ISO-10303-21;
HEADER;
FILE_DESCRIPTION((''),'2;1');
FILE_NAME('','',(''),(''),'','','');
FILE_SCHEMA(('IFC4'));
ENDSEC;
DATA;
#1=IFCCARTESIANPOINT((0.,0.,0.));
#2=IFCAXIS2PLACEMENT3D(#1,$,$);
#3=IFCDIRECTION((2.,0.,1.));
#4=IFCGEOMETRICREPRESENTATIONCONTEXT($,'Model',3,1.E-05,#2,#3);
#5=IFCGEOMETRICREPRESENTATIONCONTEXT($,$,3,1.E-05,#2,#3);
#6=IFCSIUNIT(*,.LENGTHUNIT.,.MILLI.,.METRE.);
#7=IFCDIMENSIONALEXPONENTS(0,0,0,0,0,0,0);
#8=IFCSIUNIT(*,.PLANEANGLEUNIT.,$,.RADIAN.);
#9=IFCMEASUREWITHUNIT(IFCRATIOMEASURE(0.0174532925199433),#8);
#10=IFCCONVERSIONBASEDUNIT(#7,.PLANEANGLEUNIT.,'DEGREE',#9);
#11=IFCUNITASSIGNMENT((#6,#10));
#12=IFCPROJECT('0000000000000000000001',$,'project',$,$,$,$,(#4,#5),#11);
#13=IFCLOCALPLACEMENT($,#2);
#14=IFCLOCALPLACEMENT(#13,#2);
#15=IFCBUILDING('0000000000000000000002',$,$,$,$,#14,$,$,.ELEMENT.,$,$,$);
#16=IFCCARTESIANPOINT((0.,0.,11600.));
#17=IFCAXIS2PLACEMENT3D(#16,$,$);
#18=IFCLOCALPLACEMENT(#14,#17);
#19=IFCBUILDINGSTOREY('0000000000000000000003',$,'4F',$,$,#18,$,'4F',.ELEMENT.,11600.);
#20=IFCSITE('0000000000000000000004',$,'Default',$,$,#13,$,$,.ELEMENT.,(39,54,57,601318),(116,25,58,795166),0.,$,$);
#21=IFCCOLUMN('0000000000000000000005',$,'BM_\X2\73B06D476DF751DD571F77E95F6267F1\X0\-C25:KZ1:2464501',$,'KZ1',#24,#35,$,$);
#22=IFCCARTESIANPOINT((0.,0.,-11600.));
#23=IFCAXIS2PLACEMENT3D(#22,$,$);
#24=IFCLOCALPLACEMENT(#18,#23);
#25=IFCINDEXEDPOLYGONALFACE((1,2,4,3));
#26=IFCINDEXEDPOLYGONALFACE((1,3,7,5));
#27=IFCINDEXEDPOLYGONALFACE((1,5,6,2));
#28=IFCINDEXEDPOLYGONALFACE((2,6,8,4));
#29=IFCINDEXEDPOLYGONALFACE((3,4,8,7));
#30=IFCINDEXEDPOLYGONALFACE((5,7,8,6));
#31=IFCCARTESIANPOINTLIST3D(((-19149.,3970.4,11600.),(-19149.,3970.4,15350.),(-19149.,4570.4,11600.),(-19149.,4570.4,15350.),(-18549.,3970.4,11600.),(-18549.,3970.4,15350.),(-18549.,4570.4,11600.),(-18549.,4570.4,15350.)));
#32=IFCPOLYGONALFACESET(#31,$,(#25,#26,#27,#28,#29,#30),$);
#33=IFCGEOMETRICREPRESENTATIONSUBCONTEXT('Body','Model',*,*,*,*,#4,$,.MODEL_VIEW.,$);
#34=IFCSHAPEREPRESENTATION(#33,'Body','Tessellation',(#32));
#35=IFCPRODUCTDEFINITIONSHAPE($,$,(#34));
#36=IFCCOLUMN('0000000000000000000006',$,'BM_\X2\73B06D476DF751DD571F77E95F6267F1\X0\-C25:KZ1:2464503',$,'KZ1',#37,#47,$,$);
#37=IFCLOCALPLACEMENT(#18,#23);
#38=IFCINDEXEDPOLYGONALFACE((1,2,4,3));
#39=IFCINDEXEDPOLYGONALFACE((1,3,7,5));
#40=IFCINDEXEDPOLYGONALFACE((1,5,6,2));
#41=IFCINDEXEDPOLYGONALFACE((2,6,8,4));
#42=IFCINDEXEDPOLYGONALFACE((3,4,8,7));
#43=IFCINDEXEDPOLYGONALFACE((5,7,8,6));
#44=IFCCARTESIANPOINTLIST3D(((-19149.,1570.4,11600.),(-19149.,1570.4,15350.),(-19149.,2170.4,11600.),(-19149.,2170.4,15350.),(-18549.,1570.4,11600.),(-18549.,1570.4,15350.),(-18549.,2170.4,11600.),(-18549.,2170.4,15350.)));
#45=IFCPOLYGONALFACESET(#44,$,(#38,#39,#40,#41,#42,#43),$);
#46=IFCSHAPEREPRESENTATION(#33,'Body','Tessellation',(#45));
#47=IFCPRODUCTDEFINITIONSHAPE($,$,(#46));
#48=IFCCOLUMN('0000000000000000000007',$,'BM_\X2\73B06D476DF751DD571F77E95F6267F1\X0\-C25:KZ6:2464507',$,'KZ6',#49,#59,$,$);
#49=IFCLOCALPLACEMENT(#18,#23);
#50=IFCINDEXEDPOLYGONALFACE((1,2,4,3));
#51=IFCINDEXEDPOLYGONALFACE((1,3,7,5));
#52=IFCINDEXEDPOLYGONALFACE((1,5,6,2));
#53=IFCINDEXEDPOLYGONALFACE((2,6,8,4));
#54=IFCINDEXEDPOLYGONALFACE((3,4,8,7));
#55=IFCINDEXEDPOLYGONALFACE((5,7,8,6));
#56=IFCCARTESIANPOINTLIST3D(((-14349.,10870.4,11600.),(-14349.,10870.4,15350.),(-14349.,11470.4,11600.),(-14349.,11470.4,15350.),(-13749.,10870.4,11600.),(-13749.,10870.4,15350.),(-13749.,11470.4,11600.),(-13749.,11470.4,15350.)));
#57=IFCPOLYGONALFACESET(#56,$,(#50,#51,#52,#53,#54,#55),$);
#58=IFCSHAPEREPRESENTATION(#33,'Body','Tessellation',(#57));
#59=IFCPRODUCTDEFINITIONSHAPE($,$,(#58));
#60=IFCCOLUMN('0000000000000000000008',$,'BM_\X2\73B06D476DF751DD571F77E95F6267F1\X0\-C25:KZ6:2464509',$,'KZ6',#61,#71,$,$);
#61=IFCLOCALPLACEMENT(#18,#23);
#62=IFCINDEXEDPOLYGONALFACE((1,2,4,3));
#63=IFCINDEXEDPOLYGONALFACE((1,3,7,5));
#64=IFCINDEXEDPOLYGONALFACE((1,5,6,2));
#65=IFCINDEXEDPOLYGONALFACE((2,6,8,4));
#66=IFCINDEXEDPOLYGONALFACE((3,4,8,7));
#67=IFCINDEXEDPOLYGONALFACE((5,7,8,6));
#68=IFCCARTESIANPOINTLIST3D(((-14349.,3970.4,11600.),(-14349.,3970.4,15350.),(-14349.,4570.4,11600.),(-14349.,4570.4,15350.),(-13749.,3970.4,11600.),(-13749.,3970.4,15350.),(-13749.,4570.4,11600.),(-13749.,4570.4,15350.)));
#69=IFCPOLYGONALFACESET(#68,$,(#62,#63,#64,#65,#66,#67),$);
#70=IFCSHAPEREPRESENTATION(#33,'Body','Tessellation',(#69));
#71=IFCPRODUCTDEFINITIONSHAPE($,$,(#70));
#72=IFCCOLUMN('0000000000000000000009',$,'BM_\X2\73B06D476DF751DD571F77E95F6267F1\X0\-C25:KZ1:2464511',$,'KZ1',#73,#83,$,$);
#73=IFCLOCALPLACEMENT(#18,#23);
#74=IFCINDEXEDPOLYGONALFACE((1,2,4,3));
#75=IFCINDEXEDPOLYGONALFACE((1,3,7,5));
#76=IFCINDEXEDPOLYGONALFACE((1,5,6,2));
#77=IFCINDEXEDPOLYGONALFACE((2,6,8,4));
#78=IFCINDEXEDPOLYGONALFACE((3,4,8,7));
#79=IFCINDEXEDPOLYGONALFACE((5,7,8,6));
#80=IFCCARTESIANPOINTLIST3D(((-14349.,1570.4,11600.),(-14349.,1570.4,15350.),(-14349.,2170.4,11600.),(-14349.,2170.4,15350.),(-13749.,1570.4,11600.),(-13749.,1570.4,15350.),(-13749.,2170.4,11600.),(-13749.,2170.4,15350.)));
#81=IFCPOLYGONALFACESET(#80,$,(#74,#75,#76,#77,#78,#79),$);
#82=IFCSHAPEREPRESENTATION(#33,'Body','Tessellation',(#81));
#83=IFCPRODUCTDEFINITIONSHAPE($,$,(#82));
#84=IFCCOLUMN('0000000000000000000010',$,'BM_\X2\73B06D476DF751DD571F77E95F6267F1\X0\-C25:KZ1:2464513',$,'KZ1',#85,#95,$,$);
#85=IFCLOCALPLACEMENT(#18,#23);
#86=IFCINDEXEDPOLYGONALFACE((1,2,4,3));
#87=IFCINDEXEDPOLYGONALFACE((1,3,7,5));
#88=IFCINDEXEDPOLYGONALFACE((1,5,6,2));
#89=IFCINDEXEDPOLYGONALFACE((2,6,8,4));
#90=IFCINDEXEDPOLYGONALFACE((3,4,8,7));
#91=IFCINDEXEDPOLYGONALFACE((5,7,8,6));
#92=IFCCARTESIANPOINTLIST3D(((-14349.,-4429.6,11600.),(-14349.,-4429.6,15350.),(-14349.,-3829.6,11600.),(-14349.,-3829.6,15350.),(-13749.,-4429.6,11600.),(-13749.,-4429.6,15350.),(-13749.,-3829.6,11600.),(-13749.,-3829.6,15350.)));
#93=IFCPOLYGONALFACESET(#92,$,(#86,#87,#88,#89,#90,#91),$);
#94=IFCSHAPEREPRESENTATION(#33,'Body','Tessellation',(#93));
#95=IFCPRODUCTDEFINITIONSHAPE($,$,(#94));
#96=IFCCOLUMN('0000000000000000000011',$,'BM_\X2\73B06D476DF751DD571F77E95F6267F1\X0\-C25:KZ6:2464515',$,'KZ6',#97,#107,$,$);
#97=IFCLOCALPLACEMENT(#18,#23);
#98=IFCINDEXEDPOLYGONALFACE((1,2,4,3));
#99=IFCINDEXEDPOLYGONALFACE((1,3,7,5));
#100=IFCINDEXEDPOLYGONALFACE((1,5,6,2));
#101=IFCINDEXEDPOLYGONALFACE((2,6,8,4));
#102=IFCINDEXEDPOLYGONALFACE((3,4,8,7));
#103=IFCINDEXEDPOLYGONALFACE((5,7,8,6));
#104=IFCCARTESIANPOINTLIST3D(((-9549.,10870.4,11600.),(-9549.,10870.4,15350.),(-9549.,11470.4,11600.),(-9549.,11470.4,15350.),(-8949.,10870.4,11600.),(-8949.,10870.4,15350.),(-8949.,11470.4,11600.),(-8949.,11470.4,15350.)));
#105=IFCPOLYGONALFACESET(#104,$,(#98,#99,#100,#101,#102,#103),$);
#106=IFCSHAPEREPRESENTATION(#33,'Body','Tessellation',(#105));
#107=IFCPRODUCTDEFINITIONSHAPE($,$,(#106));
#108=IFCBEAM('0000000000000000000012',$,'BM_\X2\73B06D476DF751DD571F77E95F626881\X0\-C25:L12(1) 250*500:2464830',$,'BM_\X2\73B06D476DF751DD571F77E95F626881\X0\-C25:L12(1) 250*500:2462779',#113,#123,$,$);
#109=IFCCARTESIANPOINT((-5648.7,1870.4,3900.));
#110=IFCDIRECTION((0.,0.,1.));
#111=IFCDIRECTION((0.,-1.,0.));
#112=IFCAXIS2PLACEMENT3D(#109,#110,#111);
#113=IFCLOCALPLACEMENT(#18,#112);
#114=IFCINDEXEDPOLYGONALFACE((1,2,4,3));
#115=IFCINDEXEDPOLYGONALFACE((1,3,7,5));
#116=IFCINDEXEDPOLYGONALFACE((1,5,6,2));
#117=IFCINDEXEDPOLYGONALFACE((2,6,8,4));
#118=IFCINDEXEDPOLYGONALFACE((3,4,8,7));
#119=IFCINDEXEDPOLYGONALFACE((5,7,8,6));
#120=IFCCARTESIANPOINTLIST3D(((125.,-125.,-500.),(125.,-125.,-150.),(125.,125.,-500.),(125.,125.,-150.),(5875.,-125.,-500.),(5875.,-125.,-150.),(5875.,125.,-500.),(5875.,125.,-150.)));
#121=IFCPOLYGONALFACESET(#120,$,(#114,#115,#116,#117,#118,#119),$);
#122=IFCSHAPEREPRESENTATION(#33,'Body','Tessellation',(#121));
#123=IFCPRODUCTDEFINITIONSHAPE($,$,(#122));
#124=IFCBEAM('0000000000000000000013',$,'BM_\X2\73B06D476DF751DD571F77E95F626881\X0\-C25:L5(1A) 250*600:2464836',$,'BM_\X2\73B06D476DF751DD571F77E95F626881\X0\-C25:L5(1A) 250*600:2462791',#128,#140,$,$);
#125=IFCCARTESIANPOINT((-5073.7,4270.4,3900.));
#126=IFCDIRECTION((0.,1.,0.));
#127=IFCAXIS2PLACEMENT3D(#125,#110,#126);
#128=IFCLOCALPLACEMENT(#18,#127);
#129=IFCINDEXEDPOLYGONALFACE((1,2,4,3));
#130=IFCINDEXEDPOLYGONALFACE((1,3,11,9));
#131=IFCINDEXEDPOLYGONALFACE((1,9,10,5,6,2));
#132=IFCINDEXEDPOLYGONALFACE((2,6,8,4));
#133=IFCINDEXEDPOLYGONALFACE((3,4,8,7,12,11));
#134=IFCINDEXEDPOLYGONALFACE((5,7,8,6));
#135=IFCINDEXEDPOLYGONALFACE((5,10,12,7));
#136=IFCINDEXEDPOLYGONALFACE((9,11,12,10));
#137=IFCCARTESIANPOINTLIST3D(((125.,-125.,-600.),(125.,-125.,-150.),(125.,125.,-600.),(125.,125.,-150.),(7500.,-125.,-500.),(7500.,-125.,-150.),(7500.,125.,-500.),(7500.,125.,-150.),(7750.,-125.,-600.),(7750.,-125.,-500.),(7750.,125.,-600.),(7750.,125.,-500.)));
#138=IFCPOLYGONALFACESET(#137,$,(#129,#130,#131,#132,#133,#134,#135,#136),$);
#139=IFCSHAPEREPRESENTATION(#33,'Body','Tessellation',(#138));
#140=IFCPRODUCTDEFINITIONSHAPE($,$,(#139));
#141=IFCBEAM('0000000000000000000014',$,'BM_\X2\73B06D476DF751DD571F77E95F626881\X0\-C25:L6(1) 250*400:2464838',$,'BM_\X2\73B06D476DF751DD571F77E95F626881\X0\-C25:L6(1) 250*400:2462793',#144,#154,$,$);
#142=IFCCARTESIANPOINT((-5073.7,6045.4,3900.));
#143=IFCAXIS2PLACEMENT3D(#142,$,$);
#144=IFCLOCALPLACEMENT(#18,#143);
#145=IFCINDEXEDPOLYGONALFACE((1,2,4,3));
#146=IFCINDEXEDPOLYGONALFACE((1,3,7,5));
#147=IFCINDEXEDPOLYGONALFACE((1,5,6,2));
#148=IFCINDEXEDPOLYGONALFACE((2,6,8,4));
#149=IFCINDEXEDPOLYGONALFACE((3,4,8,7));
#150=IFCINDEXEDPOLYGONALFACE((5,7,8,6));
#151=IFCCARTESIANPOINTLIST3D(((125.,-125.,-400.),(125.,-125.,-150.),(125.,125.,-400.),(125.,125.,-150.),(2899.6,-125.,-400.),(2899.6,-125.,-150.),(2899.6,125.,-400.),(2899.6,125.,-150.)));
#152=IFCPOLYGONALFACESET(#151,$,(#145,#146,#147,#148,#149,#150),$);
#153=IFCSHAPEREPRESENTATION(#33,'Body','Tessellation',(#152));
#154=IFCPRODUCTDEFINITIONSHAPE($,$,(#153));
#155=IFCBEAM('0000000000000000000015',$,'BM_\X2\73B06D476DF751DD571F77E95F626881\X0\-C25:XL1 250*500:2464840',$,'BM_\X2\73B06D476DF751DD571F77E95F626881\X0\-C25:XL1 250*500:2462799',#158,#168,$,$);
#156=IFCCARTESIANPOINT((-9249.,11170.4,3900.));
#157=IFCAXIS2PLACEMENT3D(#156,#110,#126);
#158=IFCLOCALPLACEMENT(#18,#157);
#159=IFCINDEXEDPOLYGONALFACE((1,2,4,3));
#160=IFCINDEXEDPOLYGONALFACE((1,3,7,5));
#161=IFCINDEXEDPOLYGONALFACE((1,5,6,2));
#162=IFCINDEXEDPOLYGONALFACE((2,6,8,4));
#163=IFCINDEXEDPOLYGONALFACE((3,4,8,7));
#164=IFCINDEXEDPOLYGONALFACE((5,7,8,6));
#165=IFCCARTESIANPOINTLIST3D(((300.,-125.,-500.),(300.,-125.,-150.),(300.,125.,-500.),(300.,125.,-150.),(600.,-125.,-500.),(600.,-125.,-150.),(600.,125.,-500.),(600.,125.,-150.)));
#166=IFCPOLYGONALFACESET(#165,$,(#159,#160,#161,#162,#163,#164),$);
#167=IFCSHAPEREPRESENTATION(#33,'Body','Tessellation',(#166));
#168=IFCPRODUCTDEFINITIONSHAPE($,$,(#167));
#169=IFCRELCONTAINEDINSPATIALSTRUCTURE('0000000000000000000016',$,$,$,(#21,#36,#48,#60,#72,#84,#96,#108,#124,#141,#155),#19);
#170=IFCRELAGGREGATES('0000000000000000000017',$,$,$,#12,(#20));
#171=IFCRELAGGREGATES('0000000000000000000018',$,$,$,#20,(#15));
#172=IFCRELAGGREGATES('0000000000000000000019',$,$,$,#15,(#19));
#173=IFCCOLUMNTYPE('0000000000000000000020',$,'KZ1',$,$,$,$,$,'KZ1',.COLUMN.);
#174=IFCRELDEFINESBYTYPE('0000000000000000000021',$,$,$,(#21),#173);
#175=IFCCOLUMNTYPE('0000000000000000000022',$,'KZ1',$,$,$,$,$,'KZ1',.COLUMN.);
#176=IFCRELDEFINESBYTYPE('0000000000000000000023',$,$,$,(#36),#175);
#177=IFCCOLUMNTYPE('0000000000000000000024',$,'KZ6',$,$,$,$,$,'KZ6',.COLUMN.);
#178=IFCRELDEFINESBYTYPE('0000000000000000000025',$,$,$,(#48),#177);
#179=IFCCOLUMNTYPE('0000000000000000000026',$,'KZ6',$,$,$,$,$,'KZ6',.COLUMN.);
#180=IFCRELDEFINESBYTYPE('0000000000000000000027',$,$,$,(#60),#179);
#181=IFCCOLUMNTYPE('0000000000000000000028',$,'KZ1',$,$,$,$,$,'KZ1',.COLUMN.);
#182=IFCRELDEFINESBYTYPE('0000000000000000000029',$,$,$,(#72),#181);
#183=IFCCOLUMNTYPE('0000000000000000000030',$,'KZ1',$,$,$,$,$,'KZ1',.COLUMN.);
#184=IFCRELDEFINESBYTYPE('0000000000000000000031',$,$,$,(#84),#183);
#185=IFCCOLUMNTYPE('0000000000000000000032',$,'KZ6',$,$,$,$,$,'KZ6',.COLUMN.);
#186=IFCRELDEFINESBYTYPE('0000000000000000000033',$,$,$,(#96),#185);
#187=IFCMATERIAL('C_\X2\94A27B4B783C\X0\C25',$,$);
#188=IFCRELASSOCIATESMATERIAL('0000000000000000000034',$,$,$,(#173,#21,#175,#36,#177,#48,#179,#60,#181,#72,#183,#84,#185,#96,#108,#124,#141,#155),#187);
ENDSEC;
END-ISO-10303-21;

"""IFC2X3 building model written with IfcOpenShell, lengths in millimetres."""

from ifc_helpers import new_model, entity, si_unit, converted_unit, direction, frame, frame_2d, origin, place, context, subcontext, project, spatial, polyline, rectangle, extrude, clip, bounded_halfspace, source, transform, mapped, material, type_object, type_shapes, element, save


model = new_model("IFC2X3")

# Units and contexts
model_context = context("Model", 3, precision=1e-05, world=origin(), true_north=direction((2.0, 0.0, 1.0)))
context_of_model = context(None, 3, precision=1e-05, world=origin(), true_north=direction((2.0, 0.0, 1.0)))
body_context = subcontext(model_context, "Body", "Model", "MODEL_VIEW")
ifc_project = project(units=[si_unit("LENGTHUNIT", "METRE", prefix="MILLI"), converted_unit("PLANEANGLEUNIT", "DEGREE", entity("IfcRatioMeasure", 0.0174532925199433), si_unit("PLANEANGLEUNIT", "RADIAN"), dimensions=[0, 0, 0, 0, 0, 0, 0])], contexts=[model_context, context_of_model])

# Site, building, storey
site_placement = place(None, origin())
site = spatial("IfcSite", under=ifc_project, at=site_placement, Name="Default", CompositionType="ELEMENT", RefLatitude=(39, 54, 57, 601318), RefLongitude=(116, 25, 58, 795166), RefElevation=0.0)
building_placement = place(site_placement, origin())
building = spatial("IfcBuilding", under=site, at=building_placement, CompositionType="ELEMENT")
storey_placement = place(building_placement, frame((0.0, 0.0, 11600.0)))
storey = spatial("IfcBuildingStorey", under=building, at=storey_placement, Name="4F", LongName="4F", CompositionType="ELEMENT", Elevation=11600.0)

# Columns
ifc_material = material(Name="C_钢筋砼C25")
column_type_1 = type_object("IfcColumnType", Name="KZ1", ElementType="KZ1", PredefinedType="COLUMN", material=ifc_material)
shared_shape_1 = source(origin(), body_context, "Body", "SweptSolid", [
    extrude(rectangle(XDim=600.0, YDim=600.0, at=frame_2d((0.0, 0.0), x_axis=(1.0, 0.0))), frame((-18849.0, 4270.4, 11600.0), z_axis=(0.0, 0.0, 1.0), x_axis=(-1.0, 0.0, 0.0)), (0.0, 0.0, 1.0), 3750.0),
])
type_shapes(column_type_1, [shared_shape_1])
column_1_placement = place(storey_placement, frame((0.0, 0.0, -11600.0)))
element("IfcColumn", 1, at=column_1_placement, inside=storey, type_object=column_type_1, material=ifc_material, Name="BM_现浇混凝土矩形柱-C25:KZ1:2464501", ObjectType="KZ1", context=body_context, shape_type="MappedRepresentation", body=[
    mapped(shared_shape_1, transform((0.0, 0.0, 0.0), scale=1.0)),
])
column_type_2 = type_object("IfcColumnType", Name="KZ1", ElementType="KZ1", PredefinedType="COLUMN", material=ifc_material)
shared_shape_2 = source(origin(), body_context, "Body", "SweptSolid", [
    extrude(rectangle(XDim=600.0, YDim=600.0, at=frame_2d((0.0, 0.0), x_axis=(1.0, 0.0))), frame((-18849.0, 1870.4, 11600.0), z_axis=(0.0, 0.0, 1.0), x_axis=(-1.0, 0.0, 0.0)), (0.0, 0.0, 1.0), 3750.0),
])
type_shapes(column_type_2, [shared_shape_2])
column_2_placement = place(storey_placement, frame((0.0, 0.0, -11600.0)))
element("IfcColumn", 2, at=column_2_placement, inside=storey, type_object=column_type_2, material=ifc_material, Name="BM_现浇混凝土矩形柱-C25:KZ1:2464503", ObjectType="KZ1", context=body_context, shape_type="MappedRepresentation", body=[
    mapped(shared_shape_2, transform((0.0, 0.0, 0.0), scale=1.0)),
])
column_type_3 = type_object("IfcColumnType", Name="KZ6", ElementType="KZ6", PredefinedType="COLUMN", material=ifc_material)
shared_shape_3 = source(origin(), body_context, "Body", "SweptSolid", [
    extrude(rectangle(XDim=600.0, YDim=600.0, at=frame_2d((0.0, 0.0), x_axis=(1.0, 0.0))), frame((-14049.0, 11170.4, 11600.0), z_axis=(0.0, 0.0, 1.0), x_axis=(-1.0, 0.0, 0.0)), (0.0, 0.0, 1.0), 3750.0),
])
type_shapes(column_type_3, [shared_shape_3])
column_3_placement = place(storey_placement, frame((0.0, 0.0, -11600.0)))
element("IfcColumn", 3, at=column_3_placement, inside=storey, type_object=column_type_3, material=ifc_material, Name="BM_现浇混凝土矩形柱-C25:KZ6:2464507", ObjectType="KZ6", context=body_context, shape_type="MappedRepresentation", body=[
    mapped(shared_shape_3, transform((0.0, 0.0, 0.0), scale=1.0)),
])
column_type_4 = type_object("IfcColumnType", Name="KZ6", ElementType="KZ6", PredefinedType="COLUMN", material=ifc_material)
shared_shape_4 = source(origin(), body_context, "Body", "SweptSolid", [
    extrude(rectangle(XDim=600.0, YDim=600.0, at=frame_2d((0.0, 0.0), x_axis=(1.0, 0.0))), frame((-14049.0, 4270.4, 11600.0), z_axis=(0.0, 0.0, 1.0), x_axis=(-1.0, 0.0, 0.0)), (0.0, 0.0, 1.0), 3750.0),
])
type_shapes(column_type_4, [shared_shape_4])
column_4_placement = place(storey_placement, frame((0.0, 0.0, -11600.0)))
element("IfcColumn", 4, at=column_4_placement, inside=storey, type_object=column_type_4, material=ifc_material, Name="BM_现浇混凝土矩形柱-C25:KZ6:2464509", ObjectType="KZ6", context=body_context, shape_type="MappedRepresentation", body=[
    mapped(shared_shape_4, transform((0.0, 0.0, 0.0), scale=1.0)),
])
column_type_5 = type_object("IfcColumnType", Name="KZ1", ElementType="KZ1", PredefinedType="COLUMN", material=ifc_material)
shared_shape_5 = source(origin(), body_context, "Body", "SweptSolid", [
    extrude(rectangle(XDim=600.0, YDim=600.0, at=frame_2d((0.0, 0.0), x_axis=(1.0, 0.0))), frame((-14049.0, 1870.4, 11600.0), z_axis=(0.0, 0.0, 1.0), x_axis=(-1.0, 0.0, 0.0)), (0.0, 0.0, 1.0), 3750.0),
])
type_shapes(column_type_5, [shared_shape_5])
column_5_placement = place(storey_placement, frame((0.0, 0.0, -11600.0)))
element("IfcColumn", 5, at=column_5_placement, inside=storey, type_object=column_type_5, material=ifc_material, Name="BM_现浇混凝土矩形柱-C25:KZ1:2464511", ObjectType="KZ1", context=body_context, shape_type="MappedRepresentation", body=[
    mapped(shared_shape_5, transform((0.0, 0.0, 0.0), scale=1.0)),
])
column_type_6 = type_object("IfcColumnType", Name="KZ1", ElementType="KZ1", PredefinedType="COLUMN", material=ifc_material)
shared_shape_6 = source(origin(), body_context, "Body", "SweptSolid", [
    extrude(rectangle(XDim=600.0, YDim=600.0, at=frame_2d((0.0, 0.0), x_axis=(1.0, 0.0))), frame((-14049.0, -4129.6, 11600.0), z_axis=(0.0, 0.0, 1.0), x_axis=(-1.0, 0.0, 0.0)), (0.0, 0.0, 1.0), 3750.0),
])
type_shapes(column_type_6, [shared_shape_6])
column_6_placement = place(storey_placement, frame((0.0, 0.0, -11600.0)))
element("IfcColumn", 6, at=column_6_placement, inside=storey, type_object=column_type_6, material=ifc_material, Name="BM_现浇混凝土矩形柱-C25:KZ1:2464513", ObjectType="KZ1", context=body_context, shape_type="MappedRepresentation", body=[
    mapped(shared_shape_6, transform((0.0, 0.0, 0.0), scale=1.0)),
])
column_type_7 = type_object("IfcColumnType", Name="KZ6", ElementType="KZ6", PredefinedType="COLUMN", material=ifc_material)
shared_shape_7 = source(origin(), body_context, "Body", "SweptSolid", [
    extrude(rectangle(XDim=600.0, YDim=600.0, at=frame_2d((0.0, 0.0), x_axis=(1.0, 0.0))), frame((-9249.0, 11170.4, 11600.0), z_axis=(0.0, 0.0, 1.0), x_axis=(-1.0, 0.0, 0.0)), (0.0, 0.0, 1.0), 3750.0),
])
type_shapes(column_type_7, [shared_shape_7])
column_7_placement = place(storey_placement, frame((0.0, 0.0, -11600.0)))
element("IfcColumn", 7, at=column_7_placement, inside=storey, type_object=column_type_7, material=ifc_material, Name="BM_现浇混凝土矩形柱-C25:KZ6:2464515", ObjectType="KZ6", context=body_context, shape_type="MappedRepresentation", body=[
    mapped(shared_shape_7, transform((0.0, 0.0, 0.0), scale=1.0)),
])

# Beams
beam_1_placement = place(storey_placement, frame((-5648.7, 1870.4, 3900.0), z_axis=(0.0, 0.0, 1.0), x_axis=(0.0, -1.0, 0.0)))
element("IfcBeam", 8, at=beam_1_placement, inside=storey, material=ifc_material, Name="BM_现浇混凝土矩形梁-C25:L12(1) 250*500:2464830", ObjectType="BM_现浇混凝土矩形梁-C25:L12(1) 250*500:2462779", context=body_context, shape_type="SweptSolid", body=[
    extrude(rectangle(XDim=350.0, YDim=250.0, at=frame_2d((0.0, 0.0), x_axis=(1.0, 0.0))), frame((125.0, 0.0, -325.0), z_axis=(1.0, 0.0, 0.0), x_axis=(0.0, 0.0, -1.0)), (0.0, 0.0, 1.0), 5750.0),
])
beam_2_placement = place(storey_placement, frame((-5073.7, 4270.4, 3900.0), z_axis=(0.0, 0.0, 1.0), x_axis=(0.0, 1.0, 0.0)))
element("IfcBeam", 9, at=beam_2_placement, inside=storey, material=ifc_material, Name="BM_现浇混凝土矩形梁-C25:L5(1A) 250*600:2464836", ObjectType="BM_现浇混凝土矩形梁-C25:L5(1A) 250*600:2462791", context=body_context, shape_type="Clipping", body=[
    clip(extrude(rectangle(XDim=450.0, YDim=250.0, at=frame_2d((0.0, 0.0), x_axis=(0.0, 1.0))), frame((125.0, 0.0, -375.0), z_axis=(1.0, 0.0, 0.0), x_axis=(0.0, 1.0, 0.0)), (0.0, 0.0, 1.0), 7625.0), bounded_halfspace(frame((7500.0, 13637.7, -500.0), z_axis=(1.0, 0.0, 0.0), x_axis=(0.0, 0.0, 1.0)), False, frame((125.0, 0.0, -375.0), z_axis=(1.0, 0.0, 0.0), x_axis=(0.0, 1.0, 0.0)), polyline([(-125.0, -125.0), (125.0, -125.0), (125.0, 225.0), (-125.0, 225.0), (-125.0, -125.0)]))),
])
beam_3_placement = place(storey_placement, frame((-5073.7, 6045.4, 3900.0)))
element("IfcBeam", 10, at=beam_3_placement, inside=storey, material=ifc_material, Name="BM_现浇混凝土矩形梁-C25:L6(1) 250*400:2464838", ObjectType="BM_现浇混凝土矩形梁-C25:L6(1) 250*400:2462793", context=body_context, shape_type="SweptSolid", body=[
    extrude(rectangle(XDim=250.0, YDim=250.0, at=frame_2d((0.0, 0.0), x_axis=(1.0, 0.0))), frame((125.0, 0.0, -275.0), z_axis=(1.0, 0.0, 0.0), x_axis=(0.0, 0.0, -1.0)), (0.0, 0.0, 1.0), 2774.6),
])
beam_4_placement = place(storey_placement, frame((-9249.0, 11170.4, 3900.0), z_axis=(0.0, 0.0, 1.0), x_axis=(0.0, 1.0, 0.0)))
element("IfcBeam", 11, at=beam_4_placement, inside=storey, material=ifc_material, Name="BM_现浇混凝土矩形梁-C25:XL1 250*500:2464840", ObjectType="BM_现浇混凝土矩形梁-C25:XL1 250*500:2462799", context=body_context, shape_type="SweptSolid", body=[
    extrude(rectangle(XDim=350.0, YDim=250.0, at=frame_2d((0.0, 0.0), x_axis=(1.0, 0.0))), frame((300.0, 0.0, -325.0), z_axis=(1.0, 0.0, 0.0), x_axis=(0.0, 0.0, -1.0)), (0.0, 0.0, 1.0), 300.0),
])

save(model, "model.ifc")
